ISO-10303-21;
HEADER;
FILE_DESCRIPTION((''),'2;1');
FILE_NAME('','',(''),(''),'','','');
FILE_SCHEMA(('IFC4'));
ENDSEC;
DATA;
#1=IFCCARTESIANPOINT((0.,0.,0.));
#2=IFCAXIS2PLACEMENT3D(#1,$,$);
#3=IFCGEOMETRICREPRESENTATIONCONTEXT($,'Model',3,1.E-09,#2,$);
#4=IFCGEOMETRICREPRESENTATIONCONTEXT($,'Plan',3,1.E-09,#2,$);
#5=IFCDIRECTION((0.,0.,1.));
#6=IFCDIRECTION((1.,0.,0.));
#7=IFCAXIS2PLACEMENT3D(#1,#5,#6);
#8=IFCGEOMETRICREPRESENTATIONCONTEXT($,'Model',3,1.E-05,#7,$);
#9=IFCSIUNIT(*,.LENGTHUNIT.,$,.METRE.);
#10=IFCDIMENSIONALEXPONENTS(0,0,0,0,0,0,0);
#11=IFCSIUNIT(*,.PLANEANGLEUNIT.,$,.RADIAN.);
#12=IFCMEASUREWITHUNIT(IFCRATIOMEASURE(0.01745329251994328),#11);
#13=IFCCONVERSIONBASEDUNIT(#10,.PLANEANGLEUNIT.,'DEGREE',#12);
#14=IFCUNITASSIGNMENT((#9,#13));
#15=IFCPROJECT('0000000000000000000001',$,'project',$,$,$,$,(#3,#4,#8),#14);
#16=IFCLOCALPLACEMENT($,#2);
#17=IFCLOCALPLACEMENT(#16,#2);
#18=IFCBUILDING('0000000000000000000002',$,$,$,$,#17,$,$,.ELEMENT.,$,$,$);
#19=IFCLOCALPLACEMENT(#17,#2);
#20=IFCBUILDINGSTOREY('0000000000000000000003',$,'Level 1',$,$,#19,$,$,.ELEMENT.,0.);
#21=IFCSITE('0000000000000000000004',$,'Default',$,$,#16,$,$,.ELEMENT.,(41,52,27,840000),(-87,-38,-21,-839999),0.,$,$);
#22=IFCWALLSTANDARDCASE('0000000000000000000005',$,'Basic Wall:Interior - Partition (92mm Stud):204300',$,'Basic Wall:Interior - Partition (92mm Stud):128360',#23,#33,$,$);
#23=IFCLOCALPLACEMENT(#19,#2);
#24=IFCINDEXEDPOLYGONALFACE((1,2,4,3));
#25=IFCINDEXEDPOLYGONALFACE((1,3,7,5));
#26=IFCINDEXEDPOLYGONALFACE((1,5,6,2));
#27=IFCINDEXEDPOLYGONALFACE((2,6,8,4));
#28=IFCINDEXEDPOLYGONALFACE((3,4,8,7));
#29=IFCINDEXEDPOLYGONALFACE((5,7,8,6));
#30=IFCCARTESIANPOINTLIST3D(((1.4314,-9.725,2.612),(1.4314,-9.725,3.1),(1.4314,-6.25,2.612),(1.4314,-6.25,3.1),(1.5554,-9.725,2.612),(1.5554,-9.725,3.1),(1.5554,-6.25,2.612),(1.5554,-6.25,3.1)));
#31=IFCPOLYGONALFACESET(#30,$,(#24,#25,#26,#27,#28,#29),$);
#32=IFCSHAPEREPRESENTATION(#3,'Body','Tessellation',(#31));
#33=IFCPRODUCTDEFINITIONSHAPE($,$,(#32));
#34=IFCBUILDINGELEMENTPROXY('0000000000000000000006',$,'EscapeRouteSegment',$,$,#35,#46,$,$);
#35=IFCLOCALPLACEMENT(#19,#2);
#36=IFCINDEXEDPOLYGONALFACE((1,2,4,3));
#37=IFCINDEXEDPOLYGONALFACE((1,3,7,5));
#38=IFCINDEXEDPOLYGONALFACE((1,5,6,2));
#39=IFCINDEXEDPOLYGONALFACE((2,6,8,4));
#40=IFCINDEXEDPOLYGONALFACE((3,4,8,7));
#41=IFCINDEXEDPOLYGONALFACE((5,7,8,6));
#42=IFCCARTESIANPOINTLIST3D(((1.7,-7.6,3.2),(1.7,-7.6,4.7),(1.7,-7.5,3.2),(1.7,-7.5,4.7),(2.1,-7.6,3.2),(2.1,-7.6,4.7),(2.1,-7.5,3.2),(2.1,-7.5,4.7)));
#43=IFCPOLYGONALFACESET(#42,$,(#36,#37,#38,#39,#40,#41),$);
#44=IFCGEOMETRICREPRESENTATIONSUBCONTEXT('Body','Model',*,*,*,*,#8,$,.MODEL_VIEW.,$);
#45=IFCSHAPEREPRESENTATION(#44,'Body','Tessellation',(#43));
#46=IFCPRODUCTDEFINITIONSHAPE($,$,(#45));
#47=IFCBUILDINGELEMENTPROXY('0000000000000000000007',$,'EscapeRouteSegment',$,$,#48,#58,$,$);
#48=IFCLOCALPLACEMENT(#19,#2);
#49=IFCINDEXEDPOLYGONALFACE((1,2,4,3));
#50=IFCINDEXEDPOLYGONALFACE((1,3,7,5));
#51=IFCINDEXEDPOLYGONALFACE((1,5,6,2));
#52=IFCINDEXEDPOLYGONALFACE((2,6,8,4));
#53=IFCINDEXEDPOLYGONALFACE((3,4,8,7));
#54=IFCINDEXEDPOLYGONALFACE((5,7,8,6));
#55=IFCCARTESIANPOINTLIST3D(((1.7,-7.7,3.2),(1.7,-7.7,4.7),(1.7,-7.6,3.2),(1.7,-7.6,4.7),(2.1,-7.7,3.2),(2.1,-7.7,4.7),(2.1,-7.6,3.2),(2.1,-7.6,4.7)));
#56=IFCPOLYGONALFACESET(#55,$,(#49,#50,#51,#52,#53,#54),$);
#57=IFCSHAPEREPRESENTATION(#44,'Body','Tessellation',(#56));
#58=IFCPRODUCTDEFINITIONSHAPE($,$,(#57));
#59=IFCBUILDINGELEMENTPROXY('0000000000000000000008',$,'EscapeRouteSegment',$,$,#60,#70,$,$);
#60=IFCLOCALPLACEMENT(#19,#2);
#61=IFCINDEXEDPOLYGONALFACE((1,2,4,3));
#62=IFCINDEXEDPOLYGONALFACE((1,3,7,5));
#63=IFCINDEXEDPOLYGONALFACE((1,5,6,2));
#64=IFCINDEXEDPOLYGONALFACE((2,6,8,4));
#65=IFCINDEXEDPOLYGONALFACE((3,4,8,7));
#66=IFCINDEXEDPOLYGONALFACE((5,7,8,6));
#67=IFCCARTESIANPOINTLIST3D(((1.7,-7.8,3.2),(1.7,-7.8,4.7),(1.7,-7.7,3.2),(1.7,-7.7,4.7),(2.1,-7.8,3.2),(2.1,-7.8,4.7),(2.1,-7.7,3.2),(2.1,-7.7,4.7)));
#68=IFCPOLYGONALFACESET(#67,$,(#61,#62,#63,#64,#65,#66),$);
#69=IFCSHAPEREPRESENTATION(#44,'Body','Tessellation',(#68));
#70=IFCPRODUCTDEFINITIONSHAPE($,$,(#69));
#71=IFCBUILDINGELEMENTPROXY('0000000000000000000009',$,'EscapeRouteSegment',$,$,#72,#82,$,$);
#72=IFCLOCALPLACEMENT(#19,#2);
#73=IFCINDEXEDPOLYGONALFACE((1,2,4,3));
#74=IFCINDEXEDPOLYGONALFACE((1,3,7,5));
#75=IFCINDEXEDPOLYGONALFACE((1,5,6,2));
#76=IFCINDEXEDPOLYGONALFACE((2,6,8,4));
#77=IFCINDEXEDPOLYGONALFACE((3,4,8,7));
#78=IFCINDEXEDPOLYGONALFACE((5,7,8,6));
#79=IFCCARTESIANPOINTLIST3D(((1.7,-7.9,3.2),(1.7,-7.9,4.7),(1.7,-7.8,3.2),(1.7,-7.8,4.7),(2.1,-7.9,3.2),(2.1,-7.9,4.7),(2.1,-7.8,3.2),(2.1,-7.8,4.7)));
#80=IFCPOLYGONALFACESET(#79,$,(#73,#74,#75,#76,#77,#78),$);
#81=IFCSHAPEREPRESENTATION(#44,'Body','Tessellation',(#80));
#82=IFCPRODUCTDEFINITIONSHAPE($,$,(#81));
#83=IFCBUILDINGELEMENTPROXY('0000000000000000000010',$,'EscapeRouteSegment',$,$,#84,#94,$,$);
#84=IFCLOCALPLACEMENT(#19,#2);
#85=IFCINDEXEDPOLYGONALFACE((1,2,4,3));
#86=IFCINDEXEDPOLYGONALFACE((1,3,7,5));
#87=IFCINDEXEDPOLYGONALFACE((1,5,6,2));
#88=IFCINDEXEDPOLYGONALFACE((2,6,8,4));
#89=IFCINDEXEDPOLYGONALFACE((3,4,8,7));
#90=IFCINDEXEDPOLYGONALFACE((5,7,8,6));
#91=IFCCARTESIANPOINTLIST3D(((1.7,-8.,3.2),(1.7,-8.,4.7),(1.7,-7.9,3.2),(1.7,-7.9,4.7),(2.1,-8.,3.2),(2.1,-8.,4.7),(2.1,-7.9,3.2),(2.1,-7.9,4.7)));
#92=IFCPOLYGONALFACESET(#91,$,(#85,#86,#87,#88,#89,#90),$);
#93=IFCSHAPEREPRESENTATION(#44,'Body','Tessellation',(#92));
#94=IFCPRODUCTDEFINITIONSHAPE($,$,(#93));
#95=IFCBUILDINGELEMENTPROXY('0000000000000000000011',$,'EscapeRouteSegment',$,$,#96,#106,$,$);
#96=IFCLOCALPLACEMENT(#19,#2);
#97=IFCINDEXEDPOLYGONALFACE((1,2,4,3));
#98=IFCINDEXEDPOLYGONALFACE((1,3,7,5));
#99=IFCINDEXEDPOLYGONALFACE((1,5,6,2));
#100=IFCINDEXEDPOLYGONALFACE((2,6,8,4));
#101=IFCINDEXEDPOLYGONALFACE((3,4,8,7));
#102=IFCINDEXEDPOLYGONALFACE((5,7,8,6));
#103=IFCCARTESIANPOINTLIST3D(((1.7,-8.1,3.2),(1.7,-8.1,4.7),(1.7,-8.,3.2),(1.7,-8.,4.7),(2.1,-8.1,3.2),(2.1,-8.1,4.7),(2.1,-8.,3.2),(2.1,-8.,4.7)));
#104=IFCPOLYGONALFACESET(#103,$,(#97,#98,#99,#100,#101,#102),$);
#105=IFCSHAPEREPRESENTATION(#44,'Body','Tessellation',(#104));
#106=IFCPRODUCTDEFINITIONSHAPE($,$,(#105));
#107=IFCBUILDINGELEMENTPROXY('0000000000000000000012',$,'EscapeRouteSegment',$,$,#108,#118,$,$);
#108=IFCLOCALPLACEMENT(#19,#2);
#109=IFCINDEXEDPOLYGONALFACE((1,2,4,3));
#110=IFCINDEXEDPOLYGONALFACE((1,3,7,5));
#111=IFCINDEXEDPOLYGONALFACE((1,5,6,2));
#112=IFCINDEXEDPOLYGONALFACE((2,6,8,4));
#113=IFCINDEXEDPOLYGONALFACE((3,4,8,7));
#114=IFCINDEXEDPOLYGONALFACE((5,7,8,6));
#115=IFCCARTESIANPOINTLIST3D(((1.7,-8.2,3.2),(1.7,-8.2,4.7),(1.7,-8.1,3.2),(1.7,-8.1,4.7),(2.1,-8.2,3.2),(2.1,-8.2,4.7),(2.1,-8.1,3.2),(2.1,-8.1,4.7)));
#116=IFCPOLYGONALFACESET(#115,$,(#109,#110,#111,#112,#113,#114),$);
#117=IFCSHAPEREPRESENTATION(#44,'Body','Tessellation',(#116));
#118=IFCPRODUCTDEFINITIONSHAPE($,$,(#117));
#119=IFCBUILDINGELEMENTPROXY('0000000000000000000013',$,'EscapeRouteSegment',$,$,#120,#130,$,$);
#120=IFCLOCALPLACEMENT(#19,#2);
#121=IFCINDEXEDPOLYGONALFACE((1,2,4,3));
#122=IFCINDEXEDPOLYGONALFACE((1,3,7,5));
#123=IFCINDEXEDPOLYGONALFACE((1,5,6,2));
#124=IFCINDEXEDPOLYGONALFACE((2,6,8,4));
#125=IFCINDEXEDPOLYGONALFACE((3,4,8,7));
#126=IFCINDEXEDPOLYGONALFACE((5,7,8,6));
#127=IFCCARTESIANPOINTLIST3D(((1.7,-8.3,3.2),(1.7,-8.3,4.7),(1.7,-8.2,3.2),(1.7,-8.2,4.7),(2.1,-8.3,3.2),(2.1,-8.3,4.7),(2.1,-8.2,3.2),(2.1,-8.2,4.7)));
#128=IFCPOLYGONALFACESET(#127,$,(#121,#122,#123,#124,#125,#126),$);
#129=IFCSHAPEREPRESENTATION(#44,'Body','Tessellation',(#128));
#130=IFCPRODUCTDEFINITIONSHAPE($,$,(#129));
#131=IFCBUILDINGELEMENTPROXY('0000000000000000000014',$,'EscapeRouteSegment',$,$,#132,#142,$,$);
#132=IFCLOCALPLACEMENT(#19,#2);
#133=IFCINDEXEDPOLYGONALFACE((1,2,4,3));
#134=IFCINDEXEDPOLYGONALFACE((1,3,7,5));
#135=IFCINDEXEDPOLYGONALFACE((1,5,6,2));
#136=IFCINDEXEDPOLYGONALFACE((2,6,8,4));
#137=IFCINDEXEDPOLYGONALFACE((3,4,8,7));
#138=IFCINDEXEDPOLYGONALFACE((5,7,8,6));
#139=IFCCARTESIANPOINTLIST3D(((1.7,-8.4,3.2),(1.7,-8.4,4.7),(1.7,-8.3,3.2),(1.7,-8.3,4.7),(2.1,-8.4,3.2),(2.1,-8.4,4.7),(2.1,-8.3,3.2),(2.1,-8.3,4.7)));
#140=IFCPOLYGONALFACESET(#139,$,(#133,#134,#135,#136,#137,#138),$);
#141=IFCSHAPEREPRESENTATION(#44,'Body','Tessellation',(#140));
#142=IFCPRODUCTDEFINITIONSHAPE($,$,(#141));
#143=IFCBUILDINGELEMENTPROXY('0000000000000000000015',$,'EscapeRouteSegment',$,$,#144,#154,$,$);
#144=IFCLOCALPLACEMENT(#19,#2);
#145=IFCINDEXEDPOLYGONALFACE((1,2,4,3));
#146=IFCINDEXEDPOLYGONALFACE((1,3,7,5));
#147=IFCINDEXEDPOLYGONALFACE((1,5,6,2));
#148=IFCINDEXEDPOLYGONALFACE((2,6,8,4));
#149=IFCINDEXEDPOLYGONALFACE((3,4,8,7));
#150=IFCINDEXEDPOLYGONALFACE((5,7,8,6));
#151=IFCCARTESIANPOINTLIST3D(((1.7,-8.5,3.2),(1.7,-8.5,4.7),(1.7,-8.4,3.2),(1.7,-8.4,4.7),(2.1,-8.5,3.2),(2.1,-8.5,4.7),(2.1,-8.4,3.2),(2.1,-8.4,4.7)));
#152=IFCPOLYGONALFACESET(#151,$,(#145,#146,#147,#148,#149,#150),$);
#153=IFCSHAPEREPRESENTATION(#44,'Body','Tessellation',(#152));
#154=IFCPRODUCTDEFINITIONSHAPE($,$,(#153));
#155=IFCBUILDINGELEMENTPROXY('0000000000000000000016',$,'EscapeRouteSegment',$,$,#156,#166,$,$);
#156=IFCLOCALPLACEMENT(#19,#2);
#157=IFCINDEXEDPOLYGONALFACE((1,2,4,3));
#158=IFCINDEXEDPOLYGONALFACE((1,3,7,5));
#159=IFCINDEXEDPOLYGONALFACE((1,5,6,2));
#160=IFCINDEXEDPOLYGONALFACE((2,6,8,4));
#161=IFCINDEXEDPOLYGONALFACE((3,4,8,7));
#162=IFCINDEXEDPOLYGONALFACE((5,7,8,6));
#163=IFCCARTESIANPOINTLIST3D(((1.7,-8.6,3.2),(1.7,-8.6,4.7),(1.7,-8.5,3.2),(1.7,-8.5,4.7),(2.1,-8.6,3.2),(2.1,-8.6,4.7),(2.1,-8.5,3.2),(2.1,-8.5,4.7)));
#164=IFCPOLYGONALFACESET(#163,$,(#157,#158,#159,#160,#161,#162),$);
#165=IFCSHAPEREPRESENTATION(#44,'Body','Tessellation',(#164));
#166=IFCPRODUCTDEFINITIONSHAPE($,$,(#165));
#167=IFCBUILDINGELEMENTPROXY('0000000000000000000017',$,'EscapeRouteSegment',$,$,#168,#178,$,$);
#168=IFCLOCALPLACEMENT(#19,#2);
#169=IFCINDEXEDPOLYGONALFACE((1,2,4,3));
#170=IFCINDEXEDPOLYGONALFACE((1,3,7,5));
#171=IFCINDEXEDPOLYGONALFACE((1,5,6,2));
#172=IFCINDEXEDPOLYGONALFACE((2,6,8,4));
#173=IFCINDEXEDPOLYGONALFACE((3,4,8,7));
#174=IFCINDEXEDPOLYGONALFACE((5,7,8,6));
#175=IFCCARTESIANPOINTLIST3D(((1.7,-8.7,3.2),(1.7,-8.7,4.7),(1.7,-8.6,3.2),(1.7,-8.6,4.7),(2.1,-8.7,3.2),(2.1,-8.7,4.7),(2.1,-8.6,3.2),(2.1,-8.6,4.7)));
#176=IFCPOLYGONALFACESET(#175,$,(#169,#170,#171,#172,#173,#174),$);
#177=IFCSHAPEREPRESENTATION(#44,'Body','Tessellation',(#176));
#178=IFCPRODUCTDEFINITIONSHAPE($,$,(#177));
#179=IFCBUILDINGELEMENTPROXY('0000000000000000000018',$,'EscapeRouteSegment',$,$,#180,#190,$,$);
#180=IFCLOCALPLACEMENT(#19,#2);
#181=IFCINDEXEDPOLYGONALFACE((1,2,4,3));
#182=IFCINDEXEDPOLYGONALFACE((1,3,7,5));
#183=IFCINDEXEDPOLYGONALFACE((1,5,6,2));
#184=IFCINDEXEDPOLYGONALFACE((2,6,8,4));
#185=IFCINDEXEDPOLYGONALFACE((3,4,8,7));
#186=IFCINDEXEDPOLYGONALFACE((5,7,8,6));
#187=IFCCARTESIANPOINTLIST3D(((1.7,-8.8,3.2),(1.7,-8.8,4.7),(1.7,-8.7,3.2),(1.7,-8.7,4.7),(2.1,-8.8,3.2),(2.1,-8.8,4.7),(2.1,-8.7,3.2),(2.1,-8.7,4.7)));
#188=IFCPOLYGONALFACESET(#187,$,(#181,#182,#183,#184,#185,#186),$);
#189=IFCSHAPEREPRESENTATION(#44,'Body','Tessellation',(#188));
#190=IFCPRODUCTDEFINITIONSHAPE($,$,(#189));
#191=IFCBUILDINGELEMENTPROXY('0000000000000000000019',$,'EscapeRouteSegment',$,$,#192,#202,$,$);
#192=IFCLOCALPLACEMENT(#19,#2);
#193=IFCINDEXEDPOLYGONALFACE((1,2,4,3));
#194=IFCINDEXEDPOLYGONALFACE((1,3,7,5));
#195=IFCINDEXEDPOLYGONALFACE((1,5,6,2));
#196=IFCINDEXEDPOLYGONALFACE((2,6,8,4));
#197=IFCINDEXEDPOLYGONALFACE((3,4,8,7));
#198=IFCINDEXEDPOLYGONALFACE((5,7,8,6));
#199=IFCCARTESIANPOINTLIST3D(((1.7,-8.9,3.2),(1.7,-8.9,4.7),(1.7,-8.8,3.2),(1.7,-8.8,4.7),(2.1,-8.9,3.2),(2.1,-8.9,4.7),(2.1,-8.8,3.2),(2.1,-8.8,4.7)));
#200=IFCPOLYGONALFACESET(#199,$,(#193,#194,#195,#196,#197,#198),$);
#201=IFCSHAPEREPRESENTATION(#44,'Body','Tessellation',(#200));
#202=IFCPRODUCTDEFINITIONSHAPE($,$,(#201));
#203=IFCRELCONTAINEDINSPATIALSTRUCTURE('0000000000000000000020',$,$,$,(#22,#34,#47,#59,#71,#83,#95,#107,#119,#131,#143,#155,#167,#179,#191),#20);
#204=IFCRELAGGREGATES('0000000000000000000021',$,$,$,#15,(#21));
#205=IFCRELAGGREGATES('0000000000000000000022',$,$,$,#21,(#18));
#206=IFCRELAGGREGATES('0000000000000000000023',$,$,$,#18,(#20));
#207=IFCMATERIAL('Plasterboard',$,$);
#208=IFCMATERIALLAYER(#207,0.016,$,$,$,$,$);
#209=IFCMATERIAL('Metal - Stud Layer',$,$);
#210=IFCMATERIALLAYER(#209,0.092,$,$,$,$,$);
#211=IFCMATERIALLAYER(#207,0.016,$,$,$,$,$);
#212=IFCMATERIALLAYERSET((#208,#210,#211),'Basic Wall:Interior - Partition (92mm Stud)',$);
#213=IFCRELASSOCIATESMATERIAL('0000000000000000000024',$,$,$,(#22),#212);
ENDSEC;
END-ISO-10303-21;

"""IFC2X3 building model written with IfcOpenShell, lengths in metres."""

from ifc_helpers import new_model, entity, si_unit, converted_unit, frame, frame_2d, origin, origin_with_axes, place, context, subcontext, project, spatial, polyline, rectangle, outline, extrude, material, layer, layer_set, layer_usage, element, save


model = new_model("IFC2X3")

# Units and contexts
model_context_1 = context("Model", 3, precision=1e-09, world=origin())
plan_context = context("Plan", 3, precision=1e-09, world=origin())
model_context_2 = context("Model", 3, precision=1e-05, world=origin_with_axes())
body_context = subcontext(model_context_2, "Body", "Model", "MODEL_VIEW")
ifc_project = project(units=[si_unit("LENGTHUNIT", "METRE"), converted_unit("PLANEANGLEUNIT", "DEGREE", entity("IfcRatioMeasure", 0.01745329251994328), si_unit("PLANEANGLEUNIT", "RADIAN"), dimensions=[0, 0, 0, 0, 0, 0, 0])], contexts=[model_context_1, plan_context, model_context_2])

# Site, building, storey
site_placement = place(None, origin())
site = spatial("IfcSite", under=ifc_project, at=site_placement, Name="Default", CompositionType="ELEMENT", RefLatitude=(41, 52, 27, 840000), RefLongitude=(-87, -38, -21, -839999), RefElevation=0.0)
building_placement = place(site_placement, origin())
building = spatial("IfcBuilding", under=site, at=building_placement, CompositionType="ELEMENT")
storey_placement = place(building_placement, origin())
storey = spatial("IfcBuildingStorey", under=building, at=storey_placement, Name="Level 1", CompositionType="ELEMENT", Elevation=0.0)

# Wall
ifc_material_1 = material(Name="Plasterboard")
ifc_layer_1 = layer(ifc_material_1, 0.016)
ifc_material_2 = material(Name="Metal - Stud Layer")
ifc_layer_2 = layer(ifc_material_2, 0.092)
ifc_layer_3 = layer(ifc_material_1, 0.016)
ifc_layer_set = layer_set([ifc_layer_1, ifc_layer_2, ifc_layer_3], Name="Basic Wall:Interior - Partition (92mm Stud)")
ifc_layer_usage = layer_usage(ifc_layer_set, "AXIS2", "NEGATIVE", 0.062)
wall_placement = place(storey_placement, frame((1.4934, -6.25, 2.612), z_axis=(0.0, 0.0, 1.0), x_axis=(0.0, -1.0, 0.0)))
element("IfcWallStandardCase", 1, at=wall_placement, inside=storey, material=ifc_layer_usage, Name="Basic Wall:Interior - Partition (92mm Stud):204300", ObjectType="Basic Wall:Interior - Partition (92mm Stud):128360", context=model_context_1, shape_type="SweptSolid", body=[
    extrude(rectangle(XDim=3.475, YDim=0.124, at=frame_2d((1.7375, 0.0), x_axis=(-1.0, 0.0))), origin(), (0.0, 0.0, 1.0), 0.488),
])

# Building element proxies
for number, where, z_axis, x_axis, name in (
    (2, (1.9, -7.5, 3.2), (0.0, 0.0, 1.0), (0.0, -1.0, 0.0), "EscapeRouteSegment"),
    (3, (1.9, -7.6, 3.2), (0.0, 0.0, 1.0), (0.0, -1.0, 0.0), "EscapeRouteSegment"),
):
    element("IfcBuildingElementProxy", number, at=place(storey_placement, frame(where, z_axis=z_axis, x_axis=x_axis)), inside=storey, Name=name, context=body_context, shape_type="SweptSolid", body=[
        extrude(outline(polyline([(0.0, -0.2), (0.0, 0.2), (0.1, 0.2), (0.1, -0.2), (0.0, -0.2)])), origin_with_axes(), (0.0, 0.0, 1.0), 1.5),
    ])
proxy_1_placement = place(storey_placement, frame((1.9, -7.7, 3.2), z_axis=(0.0, 0.0, 1.0), x_axis=(0.0, -1.0, 0.0)))
element("IfcBuildingElementProxy", 4, at=proxy_1_placement, inside=storey, Name="EscapeRouteSegment", context=body_context, shape_type="SweptSolid", body=[
    extrude(outline(polyline([(0.0, -0.2), (0.0, 0.2), (0.1, 0.2), (0.1, -0.2), (0.0, -0.2)])), origin_with_axes(), (0.0, 0.0, 1.0), 1.5),
])
for number, where, z_axis, x_axis, name in (
    (5, (1.9, -7.8, 3.2), (0.0, 0.0, 1.0), (0.0, -1.0, 0.0), "EscapeRouteSegment"),
    (6, (1.9, -7.9, 3.2), (0.0, 0.0, 1.0), (0.0, -1.0, 0.0), "EscapeRouteSegment"),
):
    element("IfcBuildingElementProxy", number, at=place(storey_placement, frame(where, z_axis=z_axis, x_axis=x_axis)), inside=storey, Name=name, context=body_context, shape_type="SweptSolid", body=[
        extrude(outline(polyline([(0.0, -0.2), (0.0, 0.2), (0.1, 0.2), (0.1, -0.2), (0.0, -0.2)])), origin_with_axes(), (0.0, 0.0, 1.0), 1.5),
    ])
proxy_2_placement = place(storey_placement, frame((1.9, -8.0, 3.2), z_axis=(0.0, 0.0, 1.0), x_axis=(0.0, -1.0, 0.0)))
element("IfcBuildingElementProxy", 7, at=proxy_2_placement, inside=storey, Name="EscapeRouteSegment", context=body_context, shape_type="SweptSolid", body=[
    extrude(outline(polyline([(0.0, -0.2), (0.0, 0.2), (0.1, 0.2), (0.1, -0.2), (0.0, -0.2)])), origin_with_axes(), (0.0, 0.0, 1.0), 1.5),
])
proxy_3_placement = place(storey_placement, frame((1.9, -8.1, 3.2), z_axis=(0.0, 0.0, 1.0), x_axis=(0.0, -1.0, 0.0)))
element("IfcBuildingElementProxy", 8, at=proxy_3_placement, inside=storey, Name="EscapeRouteSegment", context=body_context, shape_type="SweptSolid", body=[
    extrude(outline(polyline([(0.0, -0.2), (0.0, 0.2), (0.1, 0.2), (0.1, -0.2), (0.0, -0.2)])), origin_with_axes(), (0.0, 0.0, 1.0), 1.5),
])
proxy_4_placement = place(storey_placement, frame((1.9, -8.2, 3.2), z_axis=(0.0, 0.0, 1.0), x_axis=(0.0, -1.0, 0.0)))
element("IfcBuildingElementProxy", 9, at=proxy_4_placement, inside=storey, Name="EscapeRouteSegment", context=body_context, shape_type="SweptSolid", body=[
    extrude(outline(polyline([(0.0, -0.2), (0.0, 0.2), (0.1, 0.2), (0.1, -0.2), (0.0, -0.2)])), origin_with_axes(), (0.0, 0.0, 1.0), 1.5),
])
proxy_5_placement = place(storey_placement, frame((1.9, -8.3, 3.2), z_axis=(0.0, 0.0, 1.0), x_axis=(0.0, -1.0, 0.0)))
element("IfcBuildingElementProxy", 10, at=proxy_5_placement, inside=storey, Name="EscapeRouteSegment", context=body_context, shape_type="SweptSolid", body=[
    extrude(outline(polyline([(0.0, -0.2), (0.0, 0.2), (0.1, 0.2), (0.1, -0.2), (0.0, -0.2)])), origin_with_axes(), (0.0, 0.0, 1.0), 1.5),
])
for number, where, z_axis, x_axis, name in (
    (11, (1.9, -8.4, 3.2), (0.0, 0.0, 1.0), (0.0, -1.0, 0.0), "EscapeRouteSegment"),
    (12, (1.9, -8.5, 3.2), (0.0, 0.0, 1.0), (0.0, -1.0, 0.0), "EscapeRouteSegment"),
):
    element("IfcBuildingElementProxy", number, at=place(storey_placement, frame(where, z_axis=z_axis, x_axis=x_axis)), inside=storey, Name=name, context=body_context, shape_type="SweptSolid", body=[
        extrude(outline(polyline([(0.0, -0.2), (0.0, 0.2), (0.1, 0.2), (0.1, -0.2), (0.0, -0.2)])), origin_with_axes(), (0.0, 0.0, 1.0), 1.5),
    ])
proxy_6_placement = place(storey_placement, frame((1.9, -8.6, 3.2), z_axis=(0.0, 0.0, 1.0), x_axis=(0.0, -1.0, 0.0)))
element("IfcBuildingElementProxy", 13, at=proxy_6_placement, inside=storey, Name="EscapeRouteSegment", context=body_context, shape_type="SweptSolid", body=[
    extrude(outline(polyline([(0.0, -0.2), (0.0, 0.2), (0.1, 0.2), (0.1, -0.2), (0.0, -0.2)])), origin_with_axes(), (0.0, 0.0, 1.0), 1.5),
])
proxy_7_placement = place(storey_placement, frame((1.9, -8.7, 3.2), z_axis=(0.0, 0.0, 1.0), x_axis=(0.0, -1.0, 0.0)))
element("IfcBuildingElementProxy", 14, at=proxy_7_placement, inside=storey, Name="EscapeRouteSegment", context=body_context, shape_type="SweptSolid", body=[
    extrude(outline(polyline([(0.0, -0.2), (0.0, 0.2), (0.1, 0.2), (0.1, -0.2), (0.0, -0.2)])), origin_with_axes(), (0.0, 0.0, 1.0), 1.5),
])
proxy_8_placement = place(storey_placement, frame((1.9, -8.8, 3.2), z_axis=(0.0, 0.0, 1.0), x_axis=(0.0, -1.0, 0.0)))
element("IfcBuildingElementProxy", 15, at=proxy_8_placement, inside=storey, Name="EscapeRouteSegment", context=body_context, shape_type="SweptSolid", body=[
    extrude(outline(polyline([(0.0, -0.2), (0.0, 0.2), (0.1, 0.2), (0.1, -0.2), (0.0, -0.2)])), origin_with_axes(), (0.0, 0.0, 1.0), 1.5),
])

save(model, "model.ifc")
